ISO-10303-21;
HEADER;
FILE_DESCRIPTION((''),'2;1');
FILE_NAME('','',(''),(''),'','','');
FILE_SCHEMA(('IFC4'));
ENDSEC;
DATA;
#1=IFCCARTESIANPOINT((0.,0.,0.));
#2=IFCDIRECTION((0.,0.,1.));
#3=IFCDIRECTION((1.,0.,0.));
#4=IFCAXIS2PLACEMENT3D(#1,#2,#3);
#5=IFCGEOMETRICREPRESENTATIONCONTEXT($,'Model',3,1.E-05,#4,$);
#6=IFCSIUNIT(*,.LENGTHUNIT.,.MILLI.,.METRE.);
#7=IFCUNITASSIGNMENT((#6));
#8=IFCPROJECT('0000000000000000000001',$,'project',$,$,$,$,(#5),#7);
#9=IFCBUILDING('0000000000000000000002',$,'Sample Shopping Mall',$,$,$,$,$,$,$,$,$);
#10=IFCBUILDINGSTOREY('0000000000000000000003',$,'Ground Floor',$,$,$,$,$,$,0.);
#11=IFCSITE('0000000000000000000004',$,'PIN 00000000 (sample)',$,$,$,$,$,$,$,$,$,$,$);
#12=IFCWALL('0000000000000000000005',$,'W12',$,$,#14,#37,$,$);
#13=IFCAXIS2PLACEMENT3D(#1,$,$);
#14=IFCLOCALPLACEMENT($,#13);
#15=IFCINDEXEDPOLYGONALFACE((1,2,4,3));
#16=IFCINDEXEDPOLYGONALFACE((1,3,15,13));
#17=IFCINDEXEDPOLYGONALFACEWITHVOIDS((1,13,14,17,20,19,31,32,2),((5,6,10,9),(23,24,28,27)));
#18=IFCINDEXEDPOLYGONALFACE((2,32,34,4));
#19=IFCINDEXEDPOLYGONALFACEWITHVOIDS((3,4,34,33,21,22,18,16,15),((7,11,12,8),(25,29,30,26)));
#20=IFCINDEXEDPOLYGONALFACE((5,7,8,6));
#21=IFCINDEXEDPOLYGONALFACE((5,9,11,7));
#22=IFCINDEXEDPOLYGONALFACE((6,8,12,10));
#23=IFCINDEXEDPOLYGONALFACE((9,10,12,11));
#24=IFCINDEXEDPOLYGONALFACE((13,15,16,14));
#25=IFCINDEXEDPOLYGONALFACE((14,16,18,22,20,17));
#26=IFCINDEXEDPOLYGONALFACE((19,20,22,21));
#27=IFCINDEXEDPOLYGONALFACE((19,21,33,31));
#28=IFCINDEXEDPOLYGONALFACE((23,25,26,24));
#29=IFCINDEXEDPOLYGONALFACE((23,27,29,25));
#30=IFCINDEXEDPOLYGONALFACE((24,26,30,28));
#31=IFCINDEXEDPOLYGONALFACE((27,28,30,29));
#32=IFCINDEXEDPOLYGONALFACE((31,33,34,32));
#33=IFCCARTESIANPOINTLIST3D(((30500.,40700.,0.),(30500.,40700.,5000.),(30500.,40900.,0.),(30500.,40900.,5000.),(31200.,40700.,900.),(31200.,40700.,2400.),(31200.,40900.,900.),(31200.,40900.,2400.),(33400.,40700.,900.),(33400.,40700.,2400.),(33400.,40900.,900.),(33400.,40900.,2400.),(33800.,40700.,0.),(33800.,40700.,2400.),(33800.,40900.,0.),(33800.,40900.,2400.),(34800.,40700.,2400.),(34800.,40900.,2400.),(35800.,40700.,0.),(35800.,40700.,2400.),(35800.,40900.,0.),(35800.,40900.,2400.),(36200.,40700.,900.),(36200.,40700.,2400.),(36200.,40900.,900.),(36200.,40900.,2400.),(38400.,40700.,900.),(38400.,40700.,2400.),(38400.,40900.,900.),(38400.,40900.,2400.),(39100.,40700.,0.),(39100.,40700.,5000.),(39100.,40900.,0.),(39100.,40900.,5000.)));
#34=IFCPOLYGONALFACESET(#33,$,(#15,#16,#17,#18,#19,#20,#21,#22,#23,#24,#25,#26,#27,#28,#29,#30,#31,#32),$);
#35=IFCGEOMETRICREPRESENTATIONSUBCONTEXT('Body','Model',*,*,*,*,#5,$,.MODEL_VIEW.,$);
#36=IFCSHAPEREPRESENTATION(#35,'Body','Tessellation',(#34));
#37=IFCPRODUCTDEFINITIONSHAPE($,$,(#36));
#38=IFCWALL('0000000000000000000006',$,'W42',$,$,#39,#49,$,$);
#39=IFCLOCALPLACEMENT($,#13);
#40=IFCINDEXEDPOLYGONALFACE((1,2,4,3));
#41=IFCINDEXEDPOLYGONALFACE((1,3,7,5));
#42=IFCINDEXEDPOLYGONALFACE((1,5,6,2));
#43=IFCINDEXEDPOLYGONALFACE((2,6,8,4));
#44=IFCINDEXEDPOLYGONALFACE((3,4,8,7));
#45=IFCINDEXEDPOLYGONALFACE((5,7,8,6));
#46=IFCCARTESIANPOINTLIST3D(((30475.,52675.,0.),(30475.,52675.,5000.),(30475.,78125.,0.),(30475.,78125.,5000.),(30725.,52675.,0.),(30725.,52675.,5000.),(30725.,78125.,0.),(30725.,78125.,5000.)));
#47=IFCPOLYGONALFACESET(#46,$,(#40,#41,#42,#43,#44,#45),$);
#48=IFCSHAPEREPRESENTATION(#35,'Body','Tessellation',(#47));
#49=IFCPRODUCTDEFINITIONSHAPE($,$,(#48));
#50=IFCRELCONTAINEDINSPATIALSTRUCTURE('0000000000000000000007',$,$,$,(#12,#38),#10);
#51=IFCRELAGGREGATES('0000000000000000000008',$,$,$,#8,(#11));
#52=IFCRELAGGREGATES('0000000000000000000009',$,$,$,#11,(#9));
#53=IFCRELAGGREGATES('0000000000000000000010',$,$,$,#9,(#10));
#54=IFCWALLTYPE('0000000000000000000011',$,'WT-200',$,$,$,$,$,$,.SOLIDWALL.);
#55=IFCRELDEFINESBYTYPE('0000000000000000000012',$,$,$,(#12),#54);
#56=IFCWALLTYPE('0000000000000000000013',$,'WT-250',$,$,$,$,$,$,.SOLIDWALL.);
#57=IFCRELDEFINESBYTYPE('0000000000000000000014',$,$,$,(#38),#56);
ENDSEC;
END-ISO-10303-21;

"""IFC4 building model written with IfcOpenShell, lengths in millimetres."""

from ifc_helpers import new_model, si_unit, frame, origin_with_axes, place, context, subcontext, project, spatial, indexed_curve, outline, extrude, type_object, element, save


model = new_model("IFC4")

# Units and contexts
model_context = context("Model", 3, precision=1e-05, world=origin_with_axes())
body_context = subcontext(model_context, "Body", "Model", "MODEL_VIEW")
ifc_project = project(units=[si_unit("LENGTHUNIT", "METRE", prefix="MILLI")], contexts=[model_context])

# Site, building, storey
site = spatial("IfcSite", under=ifc_project, Name="PIN 00000000 (sample)")
building = spatial("IfcBuilding", under=site, Name="Sample Shopping Mall")
storey = spatial("IfcBuildingStorey", under=building, Name="Ground Floor", Elevation=0.0)

# Wall, openings
wall_type_1 = type_object("IfcWallType", Name="WT-200", PredefinedType="SOLIDWALL")
wall_1_placement = place(None, frame((30500.0, 40700.0, 0.0), z_axis=(0.0, 0.0, 1.0), x_axis=(1.0, 0.0, 0.0)))
wall_1 = element("IfcWall", 1, at=wall_1_placement, inside=storey, type_object=wall_type_1, Name="W12", context=body_context, shape_type="SweptSolid", body=[
    extrude(outline(indexed_curve([(0.0, 0.0), (0.0, 200.0), (8600.0, 200.0), (8600.0, 0.0), (0.0, 0.0)], self_intersect=False)), origin_with_axes(), (0.0, 0.0, 1.0), 5000.0),
])
opening_1_placement = place(wall_1_placement, frame((3300.0, -100.0, 0.0), z_axis=(0.0, 0.0, 1.0), x_axis=(1.0, 0.0, 0.0)))
element("IfcOpeningElement", 2, at=opening_1_placement, cuts=wall_1, context=body_context, shape_type="SweptSolid", body=[
    extrude(outline(indexed_curve([(0.0, 0.0), (0.0, 400.0), (1000.0, 400.0), (1000.0, 0.0), (0.0, 0.0)], self_intersect=False)), origin_with_axes(), (0.0, 0.0, 1.0), 2400.0),
])
opening_2_placement = place(wall_1_placement, frame((4300.0, -100.0, 0.0), z_axis=(0.0, 0.0, 1.0), x_axis=(1.0, 0.0, 0.0)))
element("IfcOpeningElement", 3, at=opening_2_placement, cuts=wall_1, context=body_context, shape_type="SweptSolid", body=[
    extrude(outline(indexed_curve([(0.0, 0.0), (0.0, 400.0), (1000.0, 400.0), (1000.0, 0.0), (0.0, 0.0)], self_intersect=False)), origin_with_axes(), (0.0, 0.0, 1.0), 2400.0),
])
opening_3_placement = place(wall_1_placement, frame((700.0, -100.0, 900.0), z_axis=(0.0, 0.0, 1.0), x_axis=(1.0, 0.0, 0.0)))
element("IfcOpeningElement", 4, at=opening_3_placement, cuts=wall_1, context=body_context, shape_type="SweptSolid", body=[
    extrude(outline(indexed_curve([(0.0, 0.0), (0.0, 400.0), (2200.0, 400.0), (2200.0, 0.0), (0.0, 0.0)], self_intersect=False)), origin_with_axes(), (0.0, 0.0, 1.0), 1500.0),
])
opening_4_placement = place(wall_1_placement, frame((5700.0, -100.0, 900.0), z_axis=(0.0, 0.0, 1.0), x_axis=(1.0, 0.0, 0.0)))
element("IfcOpeningElement", 5, at=opening_4_placement, cuts=wall_1, context=body_context, shape_type="SweptSolid", body=[
    extrude(outline(indexed_curve([(0.0, 0.0), (0.0, 400.0), (2200.0, 400.0), (2200.0, 0.0), (0.0, 0.0)], self_intersect=False)), origin_with_axes(), (0.0, 0.0, 1.0), 1500.0),
])
wall_type_2 = type_object("IfcWallType", Name="WT-250", PredefinedType="SOLIDWALL")

# Wall
wall_2_placement = place(None, frame((30725.0, 52675.0, 0.0), z_axis=(0.0, 0.0, 1.0), x_axis=(0.0, 1.0, 0.0)))
element("IfcWall", 6, at=wall_2_placement, inside=storey, type_object=wall_type_2, Name="W42", context=body_context, shape_type="SweptSolid", body=[
    extrude(outline(indexed_curve([(0.0, 0.0), (0.0, 250.0), (25450.0, 250.0), (25450.0, 0.0), (0.0, 0.0)], self_intersect=False)), origin_with_axes(), (0.0, 0.0, 1.0), 5000.0),
])

save(model, "model.ifc")
